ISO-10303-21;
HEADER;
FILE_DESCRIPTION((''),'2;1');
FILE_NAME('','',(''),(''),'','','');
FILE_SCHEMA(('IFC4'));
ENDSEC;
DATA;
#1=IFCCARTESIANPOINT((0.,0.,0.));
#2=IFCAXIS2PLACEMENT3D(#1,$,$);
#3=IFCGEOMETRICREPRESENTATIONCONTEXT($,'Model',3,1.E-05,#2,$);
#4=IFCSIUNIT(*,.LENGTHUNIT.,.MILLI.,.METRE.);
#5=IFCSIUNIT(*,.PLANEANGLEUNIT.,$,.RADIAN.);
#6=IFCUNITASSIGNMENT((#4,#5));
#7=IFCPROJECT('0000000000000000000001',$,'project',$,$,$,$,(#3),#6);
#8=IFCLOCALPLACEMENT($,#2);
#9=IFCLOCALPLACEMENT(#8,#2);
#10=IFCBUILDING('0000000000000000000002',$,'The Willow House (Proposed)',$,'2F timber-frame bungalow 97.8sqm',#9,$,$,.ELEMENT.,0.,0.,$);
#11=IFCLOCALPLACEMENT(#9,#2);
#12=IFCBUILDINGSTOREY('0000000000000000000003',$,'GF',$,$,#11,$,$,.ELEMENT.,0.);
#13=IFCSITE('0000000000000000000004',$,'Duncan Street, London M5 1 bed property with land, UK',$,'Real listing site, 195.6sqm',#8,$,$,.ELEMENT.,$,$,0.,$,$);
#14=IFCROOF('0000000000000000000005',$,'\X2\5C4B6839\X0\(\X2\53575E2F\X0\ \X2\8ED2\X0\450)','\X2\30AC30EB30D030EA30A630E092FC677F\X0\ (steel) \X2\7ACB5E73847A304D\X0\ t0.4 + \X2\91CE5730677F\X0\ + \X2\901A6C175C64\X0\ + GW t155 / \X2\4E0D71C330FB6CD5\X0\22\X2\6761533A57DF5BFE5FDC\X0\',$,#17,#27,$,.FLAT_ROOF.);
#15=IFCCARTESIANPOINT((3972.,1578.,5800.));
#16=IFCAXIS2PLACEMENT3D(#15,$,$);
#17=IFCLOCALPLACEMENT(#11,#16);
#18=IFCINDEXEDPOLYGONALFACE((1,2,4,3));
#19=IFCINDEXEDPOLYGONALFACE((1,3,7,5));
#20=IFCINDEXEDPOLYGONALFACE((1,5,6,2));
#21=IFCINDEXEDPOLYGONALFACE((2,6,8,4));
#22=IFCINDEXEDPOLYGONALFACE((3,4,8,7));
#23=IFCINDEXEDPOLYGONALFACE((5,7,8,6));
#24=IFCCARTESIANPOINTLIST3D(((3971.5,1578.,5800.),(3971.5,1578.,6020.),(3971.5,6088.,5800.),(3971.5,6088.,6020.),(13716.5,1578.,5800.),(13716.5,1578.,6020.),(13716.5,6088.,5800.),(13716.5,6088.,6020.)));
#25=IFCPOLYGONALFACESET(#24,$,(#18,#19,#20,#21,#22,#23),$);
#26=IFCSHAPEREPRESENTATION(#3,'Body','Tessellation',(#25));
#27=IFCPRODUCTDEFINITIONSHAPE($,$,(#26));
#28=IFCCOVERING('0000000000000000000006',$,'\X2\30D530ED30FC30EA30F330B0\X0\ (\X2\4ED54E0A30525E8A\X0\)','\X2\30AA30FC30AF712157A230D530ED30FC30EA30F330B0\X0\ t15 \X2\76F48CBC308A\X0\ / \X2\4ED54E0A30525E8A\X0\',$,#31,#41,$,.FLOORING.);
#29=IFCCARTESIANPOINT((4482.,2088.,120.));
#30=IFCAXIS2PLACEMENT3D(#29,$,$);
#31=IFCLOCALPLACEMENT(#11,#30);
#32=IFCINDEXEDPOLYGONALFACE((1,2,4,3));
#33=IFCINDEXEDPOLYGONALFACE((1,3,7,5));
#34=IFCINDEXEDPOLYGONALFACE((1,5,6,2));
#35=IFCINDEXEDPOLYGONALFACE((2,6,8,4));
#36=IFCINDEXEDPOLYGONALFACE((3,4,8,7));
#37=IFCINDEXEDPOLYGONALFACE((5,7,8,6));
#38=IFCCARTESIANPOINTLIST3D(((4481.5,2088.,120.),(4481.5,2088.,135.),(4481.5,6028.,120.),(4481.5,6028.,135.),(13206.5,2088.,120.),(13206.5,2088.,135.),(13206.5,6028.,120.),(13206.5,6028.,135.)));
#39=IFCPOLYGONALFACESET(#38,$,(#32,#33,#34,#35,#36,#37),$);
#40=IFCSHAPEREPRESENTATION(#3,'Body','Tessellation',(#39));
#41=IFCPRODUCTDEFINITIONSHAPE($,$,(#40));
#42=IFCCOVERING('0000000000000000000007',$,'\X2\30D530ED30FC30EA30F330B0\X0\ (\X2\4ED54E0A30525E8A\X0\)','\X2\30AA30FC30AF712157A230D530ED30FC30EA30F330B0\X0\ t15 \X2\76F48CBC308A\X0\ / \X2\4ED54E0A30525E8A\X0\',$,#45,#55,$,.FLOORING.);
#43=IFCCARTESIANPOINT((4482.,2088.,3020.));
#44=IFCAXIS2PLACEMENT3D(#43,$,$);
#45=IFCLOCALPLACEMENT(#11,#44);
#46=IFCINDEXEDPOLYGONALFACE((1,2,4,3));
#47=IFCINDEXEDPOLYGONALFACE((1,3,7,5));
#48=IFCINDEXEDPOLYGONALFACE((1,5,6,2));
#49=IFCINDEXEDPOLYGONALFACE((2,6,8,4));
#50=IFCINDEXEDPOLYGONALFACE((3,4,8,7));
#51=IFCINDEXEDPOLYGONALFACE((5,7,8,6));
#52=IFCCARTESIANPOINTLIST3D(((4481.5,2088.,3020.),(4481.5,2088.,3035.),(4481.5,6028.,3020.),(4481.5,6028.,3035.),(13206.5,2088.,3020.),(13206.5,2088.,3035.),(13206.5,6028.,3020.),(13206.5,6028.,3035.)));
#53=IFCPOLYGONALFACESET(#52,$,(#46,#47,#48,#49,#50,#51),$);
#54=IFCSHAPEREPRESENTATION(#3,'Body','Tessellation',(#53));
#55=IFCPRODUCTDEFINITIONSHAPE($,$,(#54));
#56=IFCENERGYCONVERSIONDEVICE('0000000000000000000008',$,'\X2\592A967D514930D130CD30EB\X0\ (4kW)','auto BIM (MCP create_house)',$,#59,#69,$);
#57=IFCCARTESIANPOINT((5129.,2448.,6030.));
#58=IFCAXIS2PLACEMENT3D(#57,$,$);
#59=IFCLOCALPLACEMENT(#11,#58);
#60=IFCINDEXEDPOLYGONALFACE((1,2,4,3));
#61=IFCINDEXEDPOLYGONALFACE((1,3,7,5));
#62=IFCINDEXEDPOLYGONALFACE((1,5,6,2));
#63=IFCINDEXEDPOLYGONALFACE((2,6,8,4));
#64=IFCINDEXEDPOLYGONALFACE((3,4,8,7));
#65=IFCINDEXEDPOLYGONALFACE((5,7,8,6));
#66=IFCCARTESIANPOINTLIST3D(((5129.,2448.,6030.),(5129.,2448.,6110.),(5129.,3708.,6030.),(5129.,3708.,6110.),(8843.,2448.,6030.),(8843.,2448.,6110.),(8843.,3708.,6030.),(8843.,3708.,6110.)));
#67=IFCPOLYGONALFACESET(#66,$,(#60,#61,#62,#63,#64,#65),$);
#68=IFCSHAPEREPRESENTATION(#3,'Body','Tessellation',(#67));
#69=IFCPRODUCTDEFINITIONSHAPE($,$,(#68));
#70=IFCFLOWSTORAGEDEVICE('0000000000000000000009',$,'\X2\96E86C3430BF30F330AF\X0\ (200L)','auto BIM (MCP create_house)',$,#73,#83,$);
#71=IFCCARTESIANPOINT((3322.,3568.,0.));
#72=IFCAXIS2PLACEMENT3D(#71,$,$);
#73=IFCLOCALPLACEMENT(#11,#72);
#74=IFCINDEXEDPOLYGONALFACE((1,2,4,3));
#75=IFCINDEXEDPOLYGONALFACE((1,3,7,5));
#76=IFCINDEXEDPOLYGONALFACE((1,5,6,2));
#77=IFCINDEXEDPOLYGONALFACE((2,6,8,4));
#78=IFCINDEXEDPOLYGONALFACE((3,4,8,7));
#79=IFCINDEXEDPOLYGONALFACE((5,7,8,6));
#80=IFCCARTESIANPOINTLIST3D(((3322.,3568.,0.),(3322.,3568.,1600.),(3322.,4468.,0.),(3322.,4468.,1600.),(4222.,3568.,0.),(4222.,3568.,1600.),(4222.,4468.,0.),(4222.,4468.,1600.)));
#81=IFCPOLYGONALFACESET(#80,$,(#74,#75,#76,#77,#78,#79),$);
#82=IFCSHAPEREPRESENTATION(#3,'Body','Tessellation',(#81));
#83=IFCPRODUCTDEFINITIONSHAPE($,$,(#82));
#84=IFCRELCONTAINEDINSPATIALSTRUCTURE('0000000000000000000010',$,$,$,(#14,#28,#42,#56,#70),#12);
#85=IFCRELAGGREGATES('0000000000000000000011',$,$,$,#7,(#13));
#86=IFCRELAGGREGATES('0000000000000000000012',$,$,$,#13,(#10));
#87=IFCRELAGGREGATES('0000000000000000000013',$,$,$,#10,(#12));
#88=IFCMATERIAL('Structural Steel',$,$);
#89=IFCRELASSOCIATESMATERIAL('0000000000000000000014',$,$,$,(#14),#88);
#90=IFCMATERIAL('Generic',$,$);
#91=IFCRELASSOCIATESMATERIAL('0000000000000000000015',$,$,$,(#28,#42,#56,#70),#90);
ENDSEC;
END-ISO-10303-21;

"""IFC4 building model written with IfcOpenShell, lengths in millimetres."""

from ifc_helpers import new_model, si_unit, frame, frame_2d, origin, place, context, project, spatial, rectangle, extrude, material, element, save


model = new_model("IFC4")

# Units and contexts
model_context = context("Model", 3, precision=1e-05, world=origin())
ifc_project = project(units=[si_unit("LENGTHUNIT", "METRE", prefix="MILLI"), si_unit("PLANEANGLEUNIT", "RADIAN")], contexts=[model_context])

# Site, building, storey
site_placement = place(None, origin())
site = spatial("IfcSite", under=ifc_project, at=site_placement, Name="Duncan Street, London M5 1 bed property with land, UK", ObjectType="Real listing site, 195.6sqm", CompositionType="ELEMENT", RefElevation=0.0)
building_placement = place(site_placement, origin())
building = spatial("IfcBuilding", under=site, at=building_placement, Name="The Willow House (Proposed)", ObjectType="2F timber-frame bungalow 97.8sqm", CompositionType="ELEMENT", ElevationOfRefHeight=0.0, ElevationOfTerrain=0.0)
storey_placement = place(building_placement, origin())
storey = spatial("IfcBuildingStorey", under=building, at=storey_placement, Name="GF", CompositionType="ELEMENT", Elevation=0.0)

# Roof
ifc_material_1 = material(Name="Structural Steel")
for number, where, name in (
    (1, (3972.0, 1578.0, 5800.0), "屋根(南帯 軒450)"),
):
    element("IfcRoof", number, at=place(storey_placement, frame(where)), inside=storey, material=ifc_material_1, Name=name, Description="ガルバリウム鋼板 (steel) 立平葺き t0.4 + 野地板 + 通気層 + GW t155 / 不燃・法22条区域対応", PredefinedType="FLAT_ROOF", context=model_context, shape_type="SweptSolid", body=[
        extrude(rectangle(XDim=9745.0, YDim=4510.0, at=frame_2d((4872.0, 2255.0))), frame((3972.0, 1578.0, 5800.0)), (0.0, 0.0, 1.0), 220.0),
    ])

# Coverings
ifc_material_2 = material(Name="Generic")
covering_1_placement = place(storey_placement, frame((4482.0, 2088.0, 120.0)))
element("IfcCovering", 2, at=covering_1_placement, inside=storey, material=ifc_material_2, Name="フローリング (仕上げ床)", Description="オーク無垢フローリング t15 直貼り / 仕上げ床", PredefinedType="FLOORING", context=model_context, shape_type="SweptSolid", body=[
    extrude(rectangle(XDim=8725.0, YDim=3940.0, at=frame_2d((4362.0, 1970.0))), frame((4482.0, 2088.0, 120.0)), (0.0, 0.0, 1.0), 15.0),
])
covering_2_placement = place(storey_placement, frame((4482.0, 2088.0, 3020.0)))
element("IfcCovering", 3, at=covering_2_placement, inside=storey, material=ifc_material_2, Name="フローリング (仕上げ床)", Description="オーク無垢フローリング t15 直貼り / 仕上げ床", PredefinedType="FLOORING", context=model_context, shape_type="SweptSolid", body=[
    extrude(rectangle(XDim=8725.0, YDim=3940.0, at=frame_2d((4362.0, 1970.0))), frame((4482.0, 2088.0, 3020.0)), (0.0, 0.0, 1.0), 15.0),
])

# Energy conversion device
energy_conversion_device_placement = place(storey_placement, frame((5129.0, 2448.0, 6030.0)))
element("IfcEnergyConversionDevice", 4, at=energy_conversion_device_placement, inside=storey, material=ifc_material_2, Name="太陽光パネル (4kW)", Description="auto BIM (MCP create_house)", context=model_context, shape_type="SweptSolid", body=[
    extrude(rectangle(XDim=3714.0, YDim=1260.0, at=frame_2d((1857.0, 630.0))), frame((5129.0, 2448.0, 6030.0)), (0.0, 0.0, 1.0), 80.0),
])

# Flow storage device
flow_storage_device_placement = place(storey_placement, frame((3322.0, 3568.0, 0.0)))
element("IfcFlowStorageDevice", 5, at=flow_storage_device_placement, inside=storey, material=ifc_material_2, Name="雨水タンク (200L)", Description="auto BIM (MCP create_house)", context=model_context, shape_type="SweptSolid", body=[
    extrude(rectangle(XDim=900.0, YDim=900.0, at=frame_2d((450.0, 450.0))), frame((3322.0, 3568.0, 0.0)), (0.0, 0.0, 1.0), 1600.0),
])

save(model, "model.ifc")
